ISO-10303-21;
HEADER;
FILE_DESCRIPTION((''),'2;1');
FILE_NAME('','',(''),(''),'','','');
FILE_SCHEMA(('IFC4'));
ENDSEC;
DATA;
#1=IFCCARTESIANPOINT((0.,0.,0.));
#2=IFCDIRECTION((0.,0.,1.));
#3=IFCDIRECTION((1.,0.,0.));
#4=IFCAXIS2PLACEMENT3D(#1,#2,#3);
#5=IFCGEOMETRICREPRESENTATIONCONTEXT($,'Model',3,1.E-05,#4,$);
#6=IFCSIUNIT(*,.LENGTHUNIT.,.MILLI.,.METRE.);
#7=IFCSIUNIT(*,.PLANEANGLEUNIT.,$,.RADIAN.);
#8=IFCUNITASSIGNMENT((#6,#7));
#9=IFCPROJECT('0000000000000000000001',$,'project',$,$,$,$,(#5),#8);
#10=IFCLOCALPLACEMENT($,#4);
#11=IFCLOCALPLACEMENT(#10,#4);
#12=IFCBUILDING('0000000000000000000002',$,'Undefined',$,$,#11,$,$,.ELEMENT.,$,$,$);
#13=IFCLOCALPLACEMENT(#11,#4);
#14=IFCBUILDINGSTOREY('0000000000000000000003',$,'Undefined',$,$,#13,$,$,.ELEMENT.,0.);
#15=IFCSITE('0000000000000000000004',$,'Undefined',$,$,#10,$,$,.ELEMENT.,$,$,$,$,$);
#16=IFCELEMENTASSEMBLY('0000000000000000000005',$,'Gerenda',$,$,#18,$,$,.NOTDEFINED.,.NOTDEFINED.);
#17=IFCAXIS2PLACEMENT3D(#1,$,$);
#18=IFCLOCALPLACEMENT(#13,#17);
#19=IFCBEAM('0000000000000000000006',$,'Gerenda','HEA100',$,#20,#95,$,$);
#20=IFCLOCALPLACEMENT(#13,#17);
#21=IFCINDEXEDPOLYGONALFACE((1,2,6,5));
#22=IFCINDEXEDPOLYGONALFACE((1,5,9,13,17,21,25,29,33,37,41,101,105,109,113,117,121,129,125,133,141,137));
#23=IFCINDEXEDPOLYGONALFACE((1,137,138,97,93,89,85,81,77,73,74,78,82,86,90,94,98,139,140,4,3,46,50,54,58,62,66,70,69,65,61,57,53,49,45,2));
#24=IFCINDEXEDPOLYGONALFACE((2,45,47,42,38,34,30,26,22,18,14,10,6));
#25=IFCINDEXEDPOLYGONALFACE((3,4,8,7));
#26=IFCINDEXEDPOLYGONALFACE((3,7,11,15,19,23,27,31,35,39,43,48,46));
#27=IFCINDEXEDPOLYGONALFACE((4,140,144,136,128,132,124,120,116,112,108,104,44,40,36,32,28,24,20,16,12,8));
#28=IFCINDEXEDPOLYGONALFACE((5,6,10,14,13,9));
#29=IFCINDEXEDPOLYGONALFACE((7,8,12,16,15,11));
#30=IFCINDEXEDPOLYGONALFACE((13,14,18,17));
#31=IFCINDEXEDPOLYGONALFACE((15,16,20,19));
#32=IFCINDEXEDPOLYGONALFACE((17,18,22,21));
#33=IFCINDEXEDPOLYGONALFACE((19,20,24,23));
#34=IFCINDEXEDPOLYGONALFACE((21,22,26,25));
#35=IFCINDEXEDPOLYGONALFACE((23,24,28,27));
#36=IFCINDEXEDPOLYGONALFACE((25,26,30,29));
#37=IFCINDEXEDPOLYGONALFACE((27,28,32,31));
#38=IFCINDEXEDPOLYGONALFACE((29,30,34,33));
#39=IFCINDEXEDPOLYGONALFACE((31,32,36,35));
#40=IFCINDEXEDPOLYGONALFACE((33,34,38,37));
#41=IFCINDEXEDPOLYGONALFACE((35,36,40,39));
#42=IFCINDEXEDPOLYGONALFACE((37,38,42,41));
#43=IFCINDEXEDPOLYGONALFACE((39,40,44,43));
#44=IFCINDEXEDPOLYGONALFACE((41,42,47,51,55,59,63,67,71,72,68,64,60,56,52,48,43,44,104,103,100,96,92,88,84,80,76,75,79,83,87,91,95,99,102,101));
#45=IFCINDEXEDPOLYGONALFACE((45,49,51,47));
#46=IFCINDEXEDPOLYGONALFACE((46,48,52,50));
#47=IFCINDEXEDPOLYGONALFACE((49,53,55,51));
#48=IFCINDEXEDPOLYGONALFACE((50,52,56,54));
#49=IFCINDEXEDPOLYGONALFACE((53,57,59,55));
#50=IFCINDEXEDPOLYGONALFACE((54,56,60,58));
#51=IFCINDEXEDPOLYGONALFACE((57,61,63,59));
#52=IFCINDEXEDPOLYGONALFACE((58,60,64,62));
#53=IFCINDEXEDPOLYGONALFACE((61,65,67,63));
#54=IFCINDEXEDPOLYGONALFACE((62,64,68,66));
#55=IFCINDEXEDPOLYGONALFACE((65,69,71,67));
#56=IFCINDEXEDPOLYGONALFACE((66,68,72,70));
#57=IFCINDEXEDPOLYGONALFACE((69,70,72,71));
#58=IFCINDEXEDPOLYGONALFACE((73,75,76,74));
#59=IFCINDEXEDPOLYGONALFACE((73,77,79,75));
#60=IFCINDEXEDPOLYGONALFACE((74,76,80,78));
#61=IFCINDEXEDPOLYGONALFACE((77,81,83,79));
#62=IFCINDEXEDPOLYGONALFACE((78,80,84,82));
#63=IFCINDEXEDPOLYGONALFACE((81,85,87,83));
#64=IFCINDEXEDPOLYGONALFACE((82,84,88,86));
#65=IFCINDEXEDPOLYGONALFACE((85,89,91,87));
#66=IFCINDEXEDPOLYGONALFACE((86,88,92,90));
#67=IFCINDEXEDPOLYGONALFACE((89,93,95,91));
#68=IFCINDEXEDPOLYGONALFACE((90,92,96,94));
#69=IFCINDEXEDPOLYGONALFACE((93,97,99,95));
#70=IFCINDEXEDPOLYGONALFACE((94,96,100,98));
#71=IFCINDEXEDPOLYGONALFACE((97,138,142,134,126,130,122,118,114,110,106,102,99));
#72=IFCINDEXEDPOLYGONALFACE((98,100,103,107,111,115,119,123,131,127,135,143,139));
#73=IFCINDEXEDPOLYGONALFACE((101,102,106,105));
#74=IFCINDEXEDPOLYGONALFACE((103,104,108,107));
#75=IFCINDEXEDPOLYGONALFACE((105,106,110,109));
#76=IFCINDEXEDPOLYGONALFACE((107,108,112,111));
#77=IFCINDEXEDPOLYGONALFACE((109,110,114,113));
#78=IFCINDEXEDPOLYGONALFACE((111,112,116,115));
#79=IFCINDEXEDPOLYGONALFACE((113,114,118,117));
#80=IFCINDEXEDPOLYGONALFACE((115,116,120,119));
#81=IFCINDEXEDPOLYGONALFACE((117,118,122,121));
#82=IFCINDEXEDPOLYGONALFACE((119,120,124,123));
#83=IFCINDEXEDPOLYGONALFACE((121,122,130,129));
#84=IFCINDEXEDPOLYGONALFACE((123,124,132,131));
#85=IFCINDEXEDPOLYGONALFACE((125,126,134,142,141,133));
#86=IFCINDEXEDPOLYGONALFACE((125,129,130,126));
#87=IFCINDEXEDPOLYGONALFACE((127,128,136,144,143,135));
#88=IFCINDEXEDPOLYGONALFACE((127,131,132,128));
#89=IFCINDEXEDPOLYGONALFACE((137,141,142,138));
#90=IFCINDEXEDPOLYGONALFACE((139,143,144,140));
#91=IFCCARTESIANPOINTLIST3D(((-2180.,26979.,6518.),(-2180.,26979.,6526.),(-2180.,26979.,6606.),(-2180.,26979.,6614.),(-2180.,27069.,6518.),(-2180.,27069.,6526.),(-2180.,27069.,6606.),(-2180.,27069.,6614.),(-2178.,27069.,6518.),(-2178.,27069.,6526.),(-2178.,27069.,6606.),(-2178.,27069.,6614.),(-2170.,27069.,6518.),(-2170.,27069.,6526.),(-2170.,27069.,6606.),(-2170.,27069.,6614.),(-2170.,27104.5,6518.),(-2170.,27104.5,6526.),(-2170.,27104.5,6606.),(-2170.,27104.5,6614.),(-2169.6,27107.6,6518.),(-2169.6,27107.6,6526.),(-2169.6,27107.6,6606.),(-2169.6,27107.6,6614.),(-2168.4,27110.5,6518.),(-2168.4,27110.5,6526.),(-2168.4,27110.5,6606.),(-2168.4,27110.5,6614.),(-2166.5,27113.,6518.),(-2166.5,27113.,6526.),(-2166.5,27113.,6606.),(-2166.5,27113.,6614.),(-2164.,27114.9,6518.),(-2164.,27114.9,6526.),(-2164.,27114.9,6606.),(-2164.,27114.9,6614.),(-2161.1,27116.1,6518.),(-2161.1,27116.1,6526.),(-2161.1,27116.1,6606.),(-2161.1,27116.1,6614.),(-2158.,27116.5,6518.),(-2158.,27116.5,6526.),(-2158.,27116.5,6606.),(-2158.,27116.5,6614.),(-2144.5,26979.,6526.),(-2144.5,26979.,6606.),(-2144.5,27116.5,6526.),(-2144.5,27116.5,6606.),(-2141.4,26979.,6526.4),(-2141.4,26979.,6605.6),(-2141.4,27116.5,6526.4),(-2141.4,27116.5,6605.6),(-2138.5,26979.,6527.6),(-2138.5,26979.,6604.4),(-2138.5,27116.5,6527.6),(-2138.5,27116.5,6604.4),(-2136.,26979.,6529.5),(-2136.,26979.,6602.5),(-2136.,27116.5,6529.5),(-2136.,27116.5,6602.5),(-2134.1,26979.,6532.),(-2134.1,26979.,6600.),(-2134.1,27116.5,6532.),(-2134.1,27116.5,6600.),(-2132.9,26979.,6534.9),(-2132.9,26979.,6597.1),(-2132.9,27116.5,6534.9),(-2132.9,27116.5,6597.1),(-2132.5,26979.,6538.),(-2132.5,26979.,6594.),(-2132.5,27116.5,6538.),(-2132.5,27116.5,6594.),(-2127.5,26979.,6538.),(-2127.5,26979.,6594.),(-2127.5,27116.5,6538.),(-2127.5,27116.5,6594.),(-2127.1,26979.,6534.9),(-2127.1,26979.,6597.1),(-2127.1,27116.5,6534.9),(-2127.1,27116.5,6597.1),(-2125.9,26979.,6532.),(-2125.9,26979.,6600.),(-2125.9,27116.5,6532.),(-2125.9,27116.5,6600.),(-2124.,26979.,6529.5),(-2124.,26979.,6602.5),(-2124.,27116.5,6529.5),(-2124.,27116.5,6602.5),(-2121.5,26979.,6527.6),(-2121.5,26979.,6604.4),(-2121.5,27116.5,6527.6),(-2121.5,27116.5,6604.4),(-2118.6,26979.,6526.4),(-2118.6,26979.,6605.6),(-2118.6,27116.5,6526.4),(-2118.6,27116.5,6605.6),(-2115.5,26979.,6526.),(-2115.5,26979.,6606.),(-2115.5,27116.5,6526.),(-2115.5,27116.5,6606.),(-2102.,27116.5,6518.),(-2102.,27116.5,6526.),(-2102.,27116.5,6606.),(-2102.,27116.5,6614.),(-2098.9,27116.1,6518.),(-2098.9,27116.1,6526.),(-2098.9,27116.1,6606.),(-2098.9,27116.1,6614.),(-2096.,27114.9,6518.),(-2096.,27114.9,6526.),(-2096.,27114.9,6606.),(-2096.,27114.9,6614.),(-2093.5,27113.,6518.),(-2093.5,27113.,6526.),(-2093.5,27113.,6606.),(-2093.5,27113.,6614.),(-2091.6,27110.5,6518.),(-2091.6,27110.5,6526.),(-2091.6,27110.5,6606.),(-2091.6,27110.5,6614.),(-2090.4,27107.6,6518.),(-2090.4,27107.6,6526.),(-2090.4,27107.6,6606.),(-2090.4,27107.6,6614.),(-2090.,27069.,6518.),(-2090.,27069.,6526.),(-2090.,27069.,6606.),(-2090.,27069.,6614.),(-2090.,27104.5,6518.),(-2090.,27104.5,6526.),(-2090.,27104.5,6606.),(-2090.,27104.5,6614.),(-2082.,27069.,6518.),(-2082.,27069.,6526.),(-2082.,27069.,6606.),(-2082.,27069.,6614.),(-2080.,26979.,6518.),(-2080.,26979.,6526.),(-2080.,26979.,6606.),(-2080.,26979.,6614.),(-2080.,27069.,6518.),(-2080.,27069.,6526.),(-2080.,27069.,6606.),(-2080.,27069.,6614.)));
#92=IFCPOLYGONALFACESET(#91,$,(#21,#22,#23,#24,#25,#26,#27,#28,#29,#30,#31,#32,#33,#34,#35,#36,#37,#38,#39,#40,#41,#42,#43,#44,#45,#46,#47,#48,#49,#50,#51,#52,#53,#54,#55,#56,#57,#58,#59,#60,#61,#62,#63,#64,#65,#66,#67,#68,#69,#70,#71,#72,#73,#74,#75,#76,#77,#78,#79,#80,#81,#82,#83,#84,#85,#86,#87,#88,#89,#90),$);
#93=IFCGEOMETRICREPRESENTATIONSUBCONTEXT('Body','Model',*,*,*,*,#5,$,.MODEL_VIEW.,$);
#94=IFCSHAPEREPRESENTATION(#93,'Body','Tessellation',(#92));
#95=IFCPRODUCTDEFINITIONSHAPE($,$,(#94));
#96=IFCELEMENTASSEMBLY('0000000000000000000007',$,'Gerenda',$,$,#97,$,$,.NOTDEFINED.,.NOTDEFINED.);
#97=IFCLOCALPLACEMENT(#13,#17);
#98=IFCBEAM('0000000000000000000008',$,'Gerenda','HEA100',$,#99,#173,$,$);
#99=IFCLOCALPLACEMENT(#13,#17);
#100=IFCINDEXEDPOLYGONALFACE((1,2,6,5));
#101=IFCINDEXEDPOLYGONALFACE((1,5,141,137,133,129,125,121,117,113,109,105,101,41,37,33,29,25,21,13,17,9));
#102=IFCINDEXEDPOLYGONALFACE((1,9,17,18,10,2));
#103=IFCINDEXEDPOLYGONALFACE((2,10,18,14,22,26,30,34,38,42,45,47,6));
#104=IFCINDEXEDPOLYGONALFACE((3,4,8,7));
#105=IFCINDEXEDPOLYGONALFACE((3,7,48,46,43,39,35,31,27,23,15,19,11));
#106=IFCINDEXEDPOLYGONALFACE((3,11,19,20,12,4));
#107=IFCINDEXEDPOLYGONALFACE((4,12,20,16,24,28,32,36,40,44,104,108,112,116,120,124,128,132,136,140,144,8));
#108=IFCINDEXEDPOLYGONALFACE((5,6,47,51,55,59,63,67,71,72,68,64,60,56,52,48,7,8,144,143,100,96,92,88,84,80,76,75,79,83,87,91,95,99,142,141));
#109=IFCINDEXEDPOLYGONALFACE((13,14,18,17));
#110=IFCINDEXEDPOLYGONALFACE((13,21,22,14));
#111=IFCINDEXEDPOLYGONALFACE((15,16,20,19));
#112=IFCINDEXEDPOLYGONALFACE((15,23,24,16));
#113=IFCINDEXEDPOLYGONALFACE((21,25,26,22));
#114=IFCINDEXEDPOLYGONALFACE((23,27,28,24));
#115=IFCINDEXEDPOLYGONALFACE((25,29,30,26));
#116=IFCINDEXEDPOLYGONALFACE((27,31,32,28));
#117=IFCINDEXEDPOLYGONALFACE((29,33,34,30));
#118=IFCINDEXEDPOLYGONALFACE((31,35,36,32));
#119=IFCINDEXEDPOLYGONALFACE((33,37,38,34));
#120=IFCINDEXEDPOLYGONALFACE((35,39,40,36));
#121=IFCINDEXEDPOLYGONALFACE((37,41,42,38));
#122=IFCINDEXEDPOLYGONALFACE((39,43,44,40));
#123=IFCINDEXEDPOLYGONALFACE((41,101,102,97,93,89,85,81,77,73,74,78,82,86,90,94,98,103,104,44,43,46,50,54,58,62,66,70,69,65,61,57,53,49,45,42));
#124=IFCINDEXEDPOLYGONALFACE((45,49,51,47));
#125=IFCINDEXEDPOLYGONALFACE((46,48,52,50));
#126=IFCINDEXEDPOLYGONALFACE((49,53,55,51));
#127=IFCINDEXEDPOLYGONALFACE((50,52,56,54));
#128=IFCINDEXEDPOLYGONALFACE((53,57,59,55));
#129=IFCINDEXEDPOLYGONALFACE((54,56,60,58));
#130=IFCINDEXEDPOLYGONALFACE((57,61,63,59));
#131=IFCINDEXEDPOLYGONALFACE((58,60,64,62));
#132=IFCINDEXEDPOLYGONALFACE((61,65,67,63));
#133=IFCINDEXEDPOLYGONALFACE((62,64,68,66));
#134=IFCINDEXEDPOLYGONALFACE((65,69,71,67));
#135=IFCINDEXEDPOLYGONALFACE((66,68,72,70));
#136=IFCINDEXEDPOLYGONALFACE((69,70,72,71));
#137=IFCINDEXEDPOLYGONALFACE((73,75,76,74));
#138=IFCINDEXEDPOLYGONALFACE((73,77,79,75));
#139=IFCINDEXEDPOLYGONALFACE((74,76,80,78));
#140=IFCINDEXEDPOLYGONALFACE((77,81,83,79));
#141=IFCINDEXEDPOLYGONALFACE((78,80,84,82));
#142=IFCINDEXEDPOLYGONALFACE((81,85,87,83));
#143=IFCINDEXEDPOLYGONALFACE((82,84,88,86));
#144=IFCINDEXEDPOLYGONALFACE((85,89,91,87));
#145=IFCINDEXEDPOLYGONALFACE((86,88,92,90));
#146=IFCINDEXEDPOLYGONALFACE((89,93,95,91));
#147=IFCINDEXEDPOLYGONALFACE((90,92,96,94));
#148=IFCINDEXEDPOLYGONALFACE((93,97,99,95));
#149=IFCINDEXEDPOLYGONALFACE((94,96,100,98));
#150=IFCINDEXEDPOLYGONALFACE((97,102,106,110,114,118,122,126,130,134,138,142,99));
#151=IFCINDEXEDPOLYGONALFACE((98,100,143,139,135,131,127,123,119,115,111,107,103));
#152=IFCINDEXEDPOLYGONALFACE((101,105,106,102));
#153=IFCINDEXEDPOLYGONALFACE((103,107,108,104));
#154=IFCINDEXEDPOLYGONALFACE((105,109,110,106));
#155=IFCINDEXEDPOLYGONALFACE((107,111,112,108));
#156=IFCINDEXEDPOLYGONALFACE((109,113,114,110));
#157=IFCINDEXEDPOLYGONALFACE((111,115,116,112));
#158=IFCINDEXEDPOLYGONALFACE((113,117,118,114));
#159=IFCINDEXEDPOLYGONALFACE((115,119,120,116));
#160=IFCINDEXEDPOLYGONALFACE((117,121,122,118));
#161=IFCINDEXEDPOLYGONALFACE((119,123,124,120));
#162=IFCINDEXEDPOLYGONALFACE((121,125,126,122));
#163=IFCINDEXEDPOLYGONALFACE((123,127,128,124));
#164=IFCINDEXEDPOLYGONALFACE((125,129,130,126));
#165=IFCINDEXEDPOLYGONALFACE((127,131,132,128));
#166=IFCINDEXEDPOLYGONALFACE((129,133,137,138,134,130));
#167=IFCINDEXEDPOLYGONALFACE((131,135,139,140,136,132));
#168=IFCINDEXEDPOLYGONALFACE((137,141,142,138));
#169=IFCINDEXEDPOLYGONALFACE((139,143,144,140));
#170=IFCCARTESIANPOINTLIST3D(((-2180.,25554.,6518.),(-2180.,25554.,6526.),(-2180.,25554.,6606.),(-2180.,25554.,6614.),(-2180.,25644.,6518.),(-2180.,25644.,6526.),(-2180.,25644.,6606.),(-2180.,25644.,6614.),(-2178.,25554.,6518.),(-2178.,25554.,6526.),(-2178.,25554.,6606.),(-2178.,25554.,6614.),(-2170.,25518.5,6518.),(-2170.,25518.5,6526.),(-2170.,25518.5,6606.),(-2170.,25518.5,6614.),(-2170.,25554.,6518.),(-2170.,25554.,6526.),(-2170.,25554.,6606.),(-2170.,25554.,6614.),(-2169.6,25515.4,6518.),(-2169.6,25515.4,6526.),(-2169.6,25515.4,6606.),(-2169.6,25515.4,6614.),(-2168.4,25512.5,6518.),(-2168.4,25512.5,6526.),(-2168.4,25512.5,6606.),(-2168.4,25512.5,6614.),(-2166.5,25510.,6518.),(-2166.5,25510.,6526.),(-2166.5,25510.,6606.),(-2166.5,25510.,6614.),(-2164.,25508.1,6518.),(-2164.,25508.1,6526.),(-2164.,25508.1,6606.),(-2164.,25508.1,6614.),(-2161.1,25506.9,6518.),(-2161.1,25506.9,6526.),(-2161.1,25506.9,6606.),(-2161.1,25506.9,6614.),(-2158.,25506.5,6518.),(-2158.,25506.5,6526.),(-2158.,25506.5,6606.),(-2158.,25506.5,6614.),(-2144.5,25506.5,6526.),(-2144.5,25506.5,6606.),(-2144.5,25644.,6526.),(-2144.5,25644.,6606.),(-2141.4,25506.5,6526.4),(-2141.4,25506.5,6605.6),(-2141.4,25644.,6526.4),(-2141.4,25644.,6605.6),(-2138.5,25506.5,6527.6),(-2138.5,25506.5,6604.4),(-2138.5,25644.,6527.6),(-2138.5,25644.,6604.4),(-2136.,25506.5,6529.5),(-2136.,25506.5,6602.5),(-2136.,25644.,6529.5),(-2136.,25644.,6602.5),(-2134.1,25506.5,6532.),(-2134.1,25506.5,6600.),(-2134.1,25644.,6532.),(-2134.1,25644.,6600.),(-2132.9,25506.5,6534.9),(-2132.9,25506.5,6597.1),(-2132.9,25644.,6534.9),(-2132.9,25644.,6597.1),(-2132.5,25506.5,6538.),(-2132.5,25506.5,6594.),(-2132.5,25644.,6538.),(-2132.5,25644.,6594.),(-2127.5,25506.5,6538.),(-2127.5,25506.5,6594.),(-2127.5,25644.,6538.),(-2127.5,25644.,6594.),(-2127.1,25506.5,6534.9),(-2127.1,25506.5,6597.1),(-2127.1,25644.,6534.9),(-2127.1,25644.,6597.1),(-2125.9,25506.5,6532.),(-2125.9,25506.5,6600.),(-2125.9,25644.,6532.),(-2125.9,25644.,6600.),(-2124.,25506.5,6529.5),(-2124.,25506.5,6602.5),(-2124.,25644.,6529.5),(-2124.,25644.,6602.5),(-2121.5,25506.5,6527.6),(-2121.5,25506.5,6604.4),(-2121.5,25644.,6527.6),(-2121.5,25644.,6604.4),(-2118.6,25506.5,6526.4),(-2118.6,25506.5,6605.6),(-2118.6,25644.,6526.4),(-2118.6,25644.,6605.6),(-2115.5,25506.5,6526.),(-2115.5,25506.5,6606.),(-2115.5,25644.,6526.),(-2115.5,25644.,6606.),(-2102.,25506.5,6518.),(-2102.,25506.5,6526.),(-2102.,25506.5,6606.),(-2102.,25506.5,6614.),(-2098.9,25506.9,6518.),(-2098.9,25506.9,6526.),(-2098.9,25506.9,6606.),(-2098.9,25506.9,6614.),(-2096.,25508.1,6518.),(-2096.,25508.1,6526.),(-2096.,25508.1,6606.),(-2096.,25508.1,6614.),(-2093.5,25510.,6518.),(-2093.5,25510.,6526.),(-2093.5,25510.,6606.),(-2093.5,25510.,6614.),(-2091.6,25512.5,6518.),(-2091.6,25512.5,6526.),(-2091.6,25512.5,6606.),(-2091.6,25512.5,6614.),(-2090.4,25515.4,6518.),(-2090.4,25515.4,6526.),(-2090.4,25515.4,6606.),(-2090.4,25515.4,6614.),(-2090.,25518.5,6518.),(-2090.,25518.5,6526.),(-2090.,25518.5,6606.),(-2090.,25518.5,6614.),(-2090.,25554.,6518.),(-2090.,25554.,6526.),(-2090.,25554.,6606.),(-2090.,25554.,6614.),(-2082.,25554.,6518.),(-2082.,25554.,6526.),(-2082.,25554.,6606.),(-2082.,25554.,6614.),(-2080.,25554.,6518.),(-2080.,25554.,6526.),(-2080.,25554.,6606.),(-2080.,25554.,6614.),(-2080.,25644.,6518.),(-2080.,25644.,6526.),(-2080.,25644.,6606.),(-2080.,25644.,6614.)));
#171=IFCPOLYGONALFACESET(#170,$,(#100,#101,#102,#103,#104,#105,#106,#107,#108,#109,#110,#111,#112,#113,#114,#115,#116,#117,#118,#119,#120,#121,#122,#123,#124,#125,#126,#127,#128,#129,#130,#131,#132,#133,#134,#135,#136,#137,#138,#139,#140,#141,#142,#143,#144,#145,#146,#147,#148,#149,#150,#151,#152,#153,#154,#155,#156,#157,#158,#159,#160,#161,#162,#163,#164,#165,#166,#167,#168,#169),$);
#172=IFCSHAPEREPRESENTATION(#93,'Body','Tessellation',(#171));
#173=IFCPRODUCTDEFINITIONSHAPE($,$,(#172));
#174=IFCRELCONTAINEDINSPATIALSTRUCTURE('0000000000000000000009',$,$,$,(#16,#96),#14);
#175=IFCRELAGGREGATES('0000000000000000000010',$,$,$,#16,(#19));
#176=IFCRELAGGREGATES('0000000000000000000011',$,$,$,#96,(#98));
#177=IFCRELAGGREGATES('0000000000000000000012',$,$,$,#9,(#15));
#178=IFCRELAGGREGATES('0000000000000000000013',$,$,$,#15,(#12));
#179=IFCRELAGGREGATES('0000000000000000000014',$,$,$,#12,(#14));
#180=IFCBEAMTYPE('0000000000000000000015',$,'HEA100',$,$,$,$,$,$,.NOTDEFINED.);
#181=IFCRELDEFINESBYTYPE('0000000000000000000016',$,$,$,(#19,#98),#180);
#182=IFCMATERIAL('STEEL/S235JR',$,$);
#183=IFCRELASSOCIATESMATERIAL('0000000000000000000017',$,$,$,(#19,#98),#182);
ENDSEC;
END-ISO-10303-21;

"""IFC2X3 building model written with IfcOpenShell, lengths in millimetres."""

from ifc_helpers import new_model, si_unit, frame, origin_with_axes, origin_2d_with_axis, place, context, subcontext, project, spatial, polyline, i_section, outline, extrude, boolean, halfspace, material, type_object, element, aggregate, save


model = new_model("IFC2X3")

# Units and contexts
model_context = context("Model", 3, precision=1e-05, world=origin_with_axes())
body_context = subcontext(model_context, "Body", "Model", "MODEL_VIEW")
ifc_project = project(units=[si_unit("LENGTHUNIT", "METRE", prefix="MILLI"), si_unit("PLANEANGLEUNIT", "RADIAN")], contexts=[model_context])

# Site, building, storey
site_placement = place(None, origin_with_axes())
site = spatial("IfcSite", under=ifc_project, at=site_placement, Name="Undefined", CompositionType="ELEMENT")
building_placement = place(site_placement, origin_with_axes())
building = spatial("IfcBuilding", under=site, at=building_placement, Name="Undefined", CompositionType="ELEMENT")
storey_placement = place(building_placement, origin_with_axes())
storey = spatial("IfcBuildingStorey", under=building, at=storey_placement, Name="Undefined", CompositionType="ELEMENT", Elevation=0.0)

# Shared definitions
ifc_material_1 = material(Name="STEEL/S235JR")

# Element assemblies, beams
beam_type_1 = type_object("IfcBeamType", Name="HEA100", PredefinedType="NOTDEFINED")
assembly_1_placement = place(storey_placement, origin_with_axes())
assembly_1 = element("IfcElementAssembly", 1, at=assembly_1_placement, inside=storey, Name="Gerenda", AssemblyPlace="NOTDEFINED", PredefinedType="NOTDEFINED")
beam_1_placement = place(assembly_1_placement, frame((-2130.0, 26969.0, 6566.0), z_axis=(0.0, 0.0, 1.0), x_axis=(0.000003, 1.0, 0.0)))
solid_1 = boolean("DIFFERENCE", boolean("DIFFERENCE", extrude(i_section(OverallWidth=100.0, OverallDepth=96.0, WebThickness=5.0, FlangeThickness=8.0, FilletRadius=12.0, at=origin_2d_with_axis()), frame((150.0, 0.0, 1488.0), z_axis=(0.0, 0.0, -1.0), x_axis=(-1.0, -0.000003, 0.0)), (0.0, 0.0, 1.0), 3024.0), halfspace(frame((150.0, -48.0, 1478.0), z_axis=(0.0, 0.0, -1.0), x_axis=(1.0, 0.000003, 0.0)), True)), halfspace(frame((150.0, -48.0, -1526.0), z_axis=(0.0, 0.0, 1.0), x_axis=(-1.0, -0.000003, 0.0)), True))
beam_1 = element("IfcBeam", 2, at=beam_1_placement, type_object=beam_type_1, material=ifc_material_1, Name="Gerenda", Description="HEA100", context=body_context, shape_type="CSG", body=[
    boolean("DIFFERENCE", boolean("DIFFERENCE", boolean("DIFFERENCE", boolean("DIFFERENCE", extrude(i_section(OverallWidth=100.0, OverallDepth=96.0, WebThickness=5.0, FlangeThickness=8.0, FilletRadius=12.0, at=origin_2d_with_axis()), frame((150.0, 0.0, 0.0), z_axis=(-1.0, 0.0, 0.0), x_axis=(0.0, -1.0, 0.0)), (0.0, 0.0, 1.0), 150.0), extrude(outline(polyline([(0.0, 0.0), (50.0, 0.0), (50.0, 2.0), (0.0, 2.0), (0.0, 0.0)])), frame((100.0, -50.0, -51.0), z_axis=(0.0, 0.0, 1.0), x_axis=(1.0, 0.0, 0.0)), (0.0, 0.0, 1.0), 102.0)), extrude(outline(polyline([(0.0, 0.0), (50.0, 0.0), (50.0, 2.0), (0.0, 2.0), (0.0, 0.0)])), frame((150.0, 48.0, 51.0), z_axis=(0.0, 0.0, -1.0), x_axis=(-1.0, -0.000003, 0.0)), (0.0, 0.0, 1.0), 102.0)), solid_1), halfspace(frame((10.0, 0.0, -1000.0), z_axis=(1.0, 0.0, 0.0), x_axis=(0.0, -1.0, 0.0)), True)),
])
assembly_2_placement = place(storey_placement, origin_with_axes())
assembly_2 = element("IfcElementAssembly", 3, at=assembly_2_placement, inside=storey, Name="Gerenda", AssemblyPlace="NOTDEFINED", PredefinedType="NOTDEFINED")
beam_2_placement = place(assembly_2_placement, frame((-2130.0, 25504.0, 6566.0), z_axis=(0.0, 0.0, 1.0), x_axis=(0.000003, 1.0, 0.0)))
solid_2 = boolean("DIFFERENCE", boolean("DIFFERENCE", extrude(i_section(OverallWidth=100.0, OverallDepth=96.0, WebThickness=5.0, FlangeThickness=8.0, FilletRadius=12.0, at=origin_2d_with_axis()), frame((0.0, 0.0, 1488.0), z_axis=(0.0, 0.0, -1.0), x_axis=(-1.0, -0.000003, 0.0)), (0.0, 0.0, 1.0), 3024.0), halfspace(frame((0.0, -48.0, 1478.0), z_axis=(0.0, 0.0, -1.0), x_axis=(1.0, 0.000003, 0.0)), True)), halfspace(frame((0.0, -48.0, -1526.0), z_axis=(0.0, 0.0, 1.0), x_axis=(-1.0, -0.000003, 0.0)), True))
beam_2 = element("IfcBeam", 4, at=beam_2_placement, type_object=beam_type_1, material=ifc_material_1, Name="Gerenda", Description="HEA100", context=body_context, shape_type="CSG", body=[
    boolean("DIFFERENCE", boolean("DIFFERENCE", boolean("DIFFERENCE", boolean("DIFFERENCE", extrude(i_section(OverallWidth=100.0, OverallDepth=96.0, WebThickness=5.0, FlangeThickness=8.0, FilletRadius=12.0, at=origin_2d_with_axis()), frame((150.0, 0.0, 0.0), z_axis=(-1.0, 0.0, 0.0), x_axis=(0.0, -1.0, 0.0)), (0.0, 0.0, 1.0), 150.0), extrude(outline(polyline([(0.0, 0.0), (50.0, 0.0), (50.0, 2.0), (0.0, 2.0), (0.0, 0.0)])), frame((50.0, 50.0, -51.0), z_axis=(0.0, 0.0, 1.0), x_axis=(-1.0, 0.0, 0.0)), (0.0, 0.0, 1.0), 102.0)), extrude(outline(polyline([(0.0, 0.0), (50.0, 0.0), (50.0, 2.0), (0.0, 2.0), (0.0, 0.0)])), frame((50.0, -50.0, 51.0), z_axis=(0.0, 0.0, -1.0), x_axis=(-1.0, 0.0, 0.0)), (0.0, 0.0, 1.0), 102.0)), solid_2), halfspace(frame((140.0, 0.0, -1000.0), z_axis=(-1.0, 0.0, 0.0), x_axis=(0.0, 1.0, 0.0)), True)),
])

aggregate(assembly_1, [beam_1])
aggregate(assembly_2, [beam_2])

save(model, "model.ifc")
